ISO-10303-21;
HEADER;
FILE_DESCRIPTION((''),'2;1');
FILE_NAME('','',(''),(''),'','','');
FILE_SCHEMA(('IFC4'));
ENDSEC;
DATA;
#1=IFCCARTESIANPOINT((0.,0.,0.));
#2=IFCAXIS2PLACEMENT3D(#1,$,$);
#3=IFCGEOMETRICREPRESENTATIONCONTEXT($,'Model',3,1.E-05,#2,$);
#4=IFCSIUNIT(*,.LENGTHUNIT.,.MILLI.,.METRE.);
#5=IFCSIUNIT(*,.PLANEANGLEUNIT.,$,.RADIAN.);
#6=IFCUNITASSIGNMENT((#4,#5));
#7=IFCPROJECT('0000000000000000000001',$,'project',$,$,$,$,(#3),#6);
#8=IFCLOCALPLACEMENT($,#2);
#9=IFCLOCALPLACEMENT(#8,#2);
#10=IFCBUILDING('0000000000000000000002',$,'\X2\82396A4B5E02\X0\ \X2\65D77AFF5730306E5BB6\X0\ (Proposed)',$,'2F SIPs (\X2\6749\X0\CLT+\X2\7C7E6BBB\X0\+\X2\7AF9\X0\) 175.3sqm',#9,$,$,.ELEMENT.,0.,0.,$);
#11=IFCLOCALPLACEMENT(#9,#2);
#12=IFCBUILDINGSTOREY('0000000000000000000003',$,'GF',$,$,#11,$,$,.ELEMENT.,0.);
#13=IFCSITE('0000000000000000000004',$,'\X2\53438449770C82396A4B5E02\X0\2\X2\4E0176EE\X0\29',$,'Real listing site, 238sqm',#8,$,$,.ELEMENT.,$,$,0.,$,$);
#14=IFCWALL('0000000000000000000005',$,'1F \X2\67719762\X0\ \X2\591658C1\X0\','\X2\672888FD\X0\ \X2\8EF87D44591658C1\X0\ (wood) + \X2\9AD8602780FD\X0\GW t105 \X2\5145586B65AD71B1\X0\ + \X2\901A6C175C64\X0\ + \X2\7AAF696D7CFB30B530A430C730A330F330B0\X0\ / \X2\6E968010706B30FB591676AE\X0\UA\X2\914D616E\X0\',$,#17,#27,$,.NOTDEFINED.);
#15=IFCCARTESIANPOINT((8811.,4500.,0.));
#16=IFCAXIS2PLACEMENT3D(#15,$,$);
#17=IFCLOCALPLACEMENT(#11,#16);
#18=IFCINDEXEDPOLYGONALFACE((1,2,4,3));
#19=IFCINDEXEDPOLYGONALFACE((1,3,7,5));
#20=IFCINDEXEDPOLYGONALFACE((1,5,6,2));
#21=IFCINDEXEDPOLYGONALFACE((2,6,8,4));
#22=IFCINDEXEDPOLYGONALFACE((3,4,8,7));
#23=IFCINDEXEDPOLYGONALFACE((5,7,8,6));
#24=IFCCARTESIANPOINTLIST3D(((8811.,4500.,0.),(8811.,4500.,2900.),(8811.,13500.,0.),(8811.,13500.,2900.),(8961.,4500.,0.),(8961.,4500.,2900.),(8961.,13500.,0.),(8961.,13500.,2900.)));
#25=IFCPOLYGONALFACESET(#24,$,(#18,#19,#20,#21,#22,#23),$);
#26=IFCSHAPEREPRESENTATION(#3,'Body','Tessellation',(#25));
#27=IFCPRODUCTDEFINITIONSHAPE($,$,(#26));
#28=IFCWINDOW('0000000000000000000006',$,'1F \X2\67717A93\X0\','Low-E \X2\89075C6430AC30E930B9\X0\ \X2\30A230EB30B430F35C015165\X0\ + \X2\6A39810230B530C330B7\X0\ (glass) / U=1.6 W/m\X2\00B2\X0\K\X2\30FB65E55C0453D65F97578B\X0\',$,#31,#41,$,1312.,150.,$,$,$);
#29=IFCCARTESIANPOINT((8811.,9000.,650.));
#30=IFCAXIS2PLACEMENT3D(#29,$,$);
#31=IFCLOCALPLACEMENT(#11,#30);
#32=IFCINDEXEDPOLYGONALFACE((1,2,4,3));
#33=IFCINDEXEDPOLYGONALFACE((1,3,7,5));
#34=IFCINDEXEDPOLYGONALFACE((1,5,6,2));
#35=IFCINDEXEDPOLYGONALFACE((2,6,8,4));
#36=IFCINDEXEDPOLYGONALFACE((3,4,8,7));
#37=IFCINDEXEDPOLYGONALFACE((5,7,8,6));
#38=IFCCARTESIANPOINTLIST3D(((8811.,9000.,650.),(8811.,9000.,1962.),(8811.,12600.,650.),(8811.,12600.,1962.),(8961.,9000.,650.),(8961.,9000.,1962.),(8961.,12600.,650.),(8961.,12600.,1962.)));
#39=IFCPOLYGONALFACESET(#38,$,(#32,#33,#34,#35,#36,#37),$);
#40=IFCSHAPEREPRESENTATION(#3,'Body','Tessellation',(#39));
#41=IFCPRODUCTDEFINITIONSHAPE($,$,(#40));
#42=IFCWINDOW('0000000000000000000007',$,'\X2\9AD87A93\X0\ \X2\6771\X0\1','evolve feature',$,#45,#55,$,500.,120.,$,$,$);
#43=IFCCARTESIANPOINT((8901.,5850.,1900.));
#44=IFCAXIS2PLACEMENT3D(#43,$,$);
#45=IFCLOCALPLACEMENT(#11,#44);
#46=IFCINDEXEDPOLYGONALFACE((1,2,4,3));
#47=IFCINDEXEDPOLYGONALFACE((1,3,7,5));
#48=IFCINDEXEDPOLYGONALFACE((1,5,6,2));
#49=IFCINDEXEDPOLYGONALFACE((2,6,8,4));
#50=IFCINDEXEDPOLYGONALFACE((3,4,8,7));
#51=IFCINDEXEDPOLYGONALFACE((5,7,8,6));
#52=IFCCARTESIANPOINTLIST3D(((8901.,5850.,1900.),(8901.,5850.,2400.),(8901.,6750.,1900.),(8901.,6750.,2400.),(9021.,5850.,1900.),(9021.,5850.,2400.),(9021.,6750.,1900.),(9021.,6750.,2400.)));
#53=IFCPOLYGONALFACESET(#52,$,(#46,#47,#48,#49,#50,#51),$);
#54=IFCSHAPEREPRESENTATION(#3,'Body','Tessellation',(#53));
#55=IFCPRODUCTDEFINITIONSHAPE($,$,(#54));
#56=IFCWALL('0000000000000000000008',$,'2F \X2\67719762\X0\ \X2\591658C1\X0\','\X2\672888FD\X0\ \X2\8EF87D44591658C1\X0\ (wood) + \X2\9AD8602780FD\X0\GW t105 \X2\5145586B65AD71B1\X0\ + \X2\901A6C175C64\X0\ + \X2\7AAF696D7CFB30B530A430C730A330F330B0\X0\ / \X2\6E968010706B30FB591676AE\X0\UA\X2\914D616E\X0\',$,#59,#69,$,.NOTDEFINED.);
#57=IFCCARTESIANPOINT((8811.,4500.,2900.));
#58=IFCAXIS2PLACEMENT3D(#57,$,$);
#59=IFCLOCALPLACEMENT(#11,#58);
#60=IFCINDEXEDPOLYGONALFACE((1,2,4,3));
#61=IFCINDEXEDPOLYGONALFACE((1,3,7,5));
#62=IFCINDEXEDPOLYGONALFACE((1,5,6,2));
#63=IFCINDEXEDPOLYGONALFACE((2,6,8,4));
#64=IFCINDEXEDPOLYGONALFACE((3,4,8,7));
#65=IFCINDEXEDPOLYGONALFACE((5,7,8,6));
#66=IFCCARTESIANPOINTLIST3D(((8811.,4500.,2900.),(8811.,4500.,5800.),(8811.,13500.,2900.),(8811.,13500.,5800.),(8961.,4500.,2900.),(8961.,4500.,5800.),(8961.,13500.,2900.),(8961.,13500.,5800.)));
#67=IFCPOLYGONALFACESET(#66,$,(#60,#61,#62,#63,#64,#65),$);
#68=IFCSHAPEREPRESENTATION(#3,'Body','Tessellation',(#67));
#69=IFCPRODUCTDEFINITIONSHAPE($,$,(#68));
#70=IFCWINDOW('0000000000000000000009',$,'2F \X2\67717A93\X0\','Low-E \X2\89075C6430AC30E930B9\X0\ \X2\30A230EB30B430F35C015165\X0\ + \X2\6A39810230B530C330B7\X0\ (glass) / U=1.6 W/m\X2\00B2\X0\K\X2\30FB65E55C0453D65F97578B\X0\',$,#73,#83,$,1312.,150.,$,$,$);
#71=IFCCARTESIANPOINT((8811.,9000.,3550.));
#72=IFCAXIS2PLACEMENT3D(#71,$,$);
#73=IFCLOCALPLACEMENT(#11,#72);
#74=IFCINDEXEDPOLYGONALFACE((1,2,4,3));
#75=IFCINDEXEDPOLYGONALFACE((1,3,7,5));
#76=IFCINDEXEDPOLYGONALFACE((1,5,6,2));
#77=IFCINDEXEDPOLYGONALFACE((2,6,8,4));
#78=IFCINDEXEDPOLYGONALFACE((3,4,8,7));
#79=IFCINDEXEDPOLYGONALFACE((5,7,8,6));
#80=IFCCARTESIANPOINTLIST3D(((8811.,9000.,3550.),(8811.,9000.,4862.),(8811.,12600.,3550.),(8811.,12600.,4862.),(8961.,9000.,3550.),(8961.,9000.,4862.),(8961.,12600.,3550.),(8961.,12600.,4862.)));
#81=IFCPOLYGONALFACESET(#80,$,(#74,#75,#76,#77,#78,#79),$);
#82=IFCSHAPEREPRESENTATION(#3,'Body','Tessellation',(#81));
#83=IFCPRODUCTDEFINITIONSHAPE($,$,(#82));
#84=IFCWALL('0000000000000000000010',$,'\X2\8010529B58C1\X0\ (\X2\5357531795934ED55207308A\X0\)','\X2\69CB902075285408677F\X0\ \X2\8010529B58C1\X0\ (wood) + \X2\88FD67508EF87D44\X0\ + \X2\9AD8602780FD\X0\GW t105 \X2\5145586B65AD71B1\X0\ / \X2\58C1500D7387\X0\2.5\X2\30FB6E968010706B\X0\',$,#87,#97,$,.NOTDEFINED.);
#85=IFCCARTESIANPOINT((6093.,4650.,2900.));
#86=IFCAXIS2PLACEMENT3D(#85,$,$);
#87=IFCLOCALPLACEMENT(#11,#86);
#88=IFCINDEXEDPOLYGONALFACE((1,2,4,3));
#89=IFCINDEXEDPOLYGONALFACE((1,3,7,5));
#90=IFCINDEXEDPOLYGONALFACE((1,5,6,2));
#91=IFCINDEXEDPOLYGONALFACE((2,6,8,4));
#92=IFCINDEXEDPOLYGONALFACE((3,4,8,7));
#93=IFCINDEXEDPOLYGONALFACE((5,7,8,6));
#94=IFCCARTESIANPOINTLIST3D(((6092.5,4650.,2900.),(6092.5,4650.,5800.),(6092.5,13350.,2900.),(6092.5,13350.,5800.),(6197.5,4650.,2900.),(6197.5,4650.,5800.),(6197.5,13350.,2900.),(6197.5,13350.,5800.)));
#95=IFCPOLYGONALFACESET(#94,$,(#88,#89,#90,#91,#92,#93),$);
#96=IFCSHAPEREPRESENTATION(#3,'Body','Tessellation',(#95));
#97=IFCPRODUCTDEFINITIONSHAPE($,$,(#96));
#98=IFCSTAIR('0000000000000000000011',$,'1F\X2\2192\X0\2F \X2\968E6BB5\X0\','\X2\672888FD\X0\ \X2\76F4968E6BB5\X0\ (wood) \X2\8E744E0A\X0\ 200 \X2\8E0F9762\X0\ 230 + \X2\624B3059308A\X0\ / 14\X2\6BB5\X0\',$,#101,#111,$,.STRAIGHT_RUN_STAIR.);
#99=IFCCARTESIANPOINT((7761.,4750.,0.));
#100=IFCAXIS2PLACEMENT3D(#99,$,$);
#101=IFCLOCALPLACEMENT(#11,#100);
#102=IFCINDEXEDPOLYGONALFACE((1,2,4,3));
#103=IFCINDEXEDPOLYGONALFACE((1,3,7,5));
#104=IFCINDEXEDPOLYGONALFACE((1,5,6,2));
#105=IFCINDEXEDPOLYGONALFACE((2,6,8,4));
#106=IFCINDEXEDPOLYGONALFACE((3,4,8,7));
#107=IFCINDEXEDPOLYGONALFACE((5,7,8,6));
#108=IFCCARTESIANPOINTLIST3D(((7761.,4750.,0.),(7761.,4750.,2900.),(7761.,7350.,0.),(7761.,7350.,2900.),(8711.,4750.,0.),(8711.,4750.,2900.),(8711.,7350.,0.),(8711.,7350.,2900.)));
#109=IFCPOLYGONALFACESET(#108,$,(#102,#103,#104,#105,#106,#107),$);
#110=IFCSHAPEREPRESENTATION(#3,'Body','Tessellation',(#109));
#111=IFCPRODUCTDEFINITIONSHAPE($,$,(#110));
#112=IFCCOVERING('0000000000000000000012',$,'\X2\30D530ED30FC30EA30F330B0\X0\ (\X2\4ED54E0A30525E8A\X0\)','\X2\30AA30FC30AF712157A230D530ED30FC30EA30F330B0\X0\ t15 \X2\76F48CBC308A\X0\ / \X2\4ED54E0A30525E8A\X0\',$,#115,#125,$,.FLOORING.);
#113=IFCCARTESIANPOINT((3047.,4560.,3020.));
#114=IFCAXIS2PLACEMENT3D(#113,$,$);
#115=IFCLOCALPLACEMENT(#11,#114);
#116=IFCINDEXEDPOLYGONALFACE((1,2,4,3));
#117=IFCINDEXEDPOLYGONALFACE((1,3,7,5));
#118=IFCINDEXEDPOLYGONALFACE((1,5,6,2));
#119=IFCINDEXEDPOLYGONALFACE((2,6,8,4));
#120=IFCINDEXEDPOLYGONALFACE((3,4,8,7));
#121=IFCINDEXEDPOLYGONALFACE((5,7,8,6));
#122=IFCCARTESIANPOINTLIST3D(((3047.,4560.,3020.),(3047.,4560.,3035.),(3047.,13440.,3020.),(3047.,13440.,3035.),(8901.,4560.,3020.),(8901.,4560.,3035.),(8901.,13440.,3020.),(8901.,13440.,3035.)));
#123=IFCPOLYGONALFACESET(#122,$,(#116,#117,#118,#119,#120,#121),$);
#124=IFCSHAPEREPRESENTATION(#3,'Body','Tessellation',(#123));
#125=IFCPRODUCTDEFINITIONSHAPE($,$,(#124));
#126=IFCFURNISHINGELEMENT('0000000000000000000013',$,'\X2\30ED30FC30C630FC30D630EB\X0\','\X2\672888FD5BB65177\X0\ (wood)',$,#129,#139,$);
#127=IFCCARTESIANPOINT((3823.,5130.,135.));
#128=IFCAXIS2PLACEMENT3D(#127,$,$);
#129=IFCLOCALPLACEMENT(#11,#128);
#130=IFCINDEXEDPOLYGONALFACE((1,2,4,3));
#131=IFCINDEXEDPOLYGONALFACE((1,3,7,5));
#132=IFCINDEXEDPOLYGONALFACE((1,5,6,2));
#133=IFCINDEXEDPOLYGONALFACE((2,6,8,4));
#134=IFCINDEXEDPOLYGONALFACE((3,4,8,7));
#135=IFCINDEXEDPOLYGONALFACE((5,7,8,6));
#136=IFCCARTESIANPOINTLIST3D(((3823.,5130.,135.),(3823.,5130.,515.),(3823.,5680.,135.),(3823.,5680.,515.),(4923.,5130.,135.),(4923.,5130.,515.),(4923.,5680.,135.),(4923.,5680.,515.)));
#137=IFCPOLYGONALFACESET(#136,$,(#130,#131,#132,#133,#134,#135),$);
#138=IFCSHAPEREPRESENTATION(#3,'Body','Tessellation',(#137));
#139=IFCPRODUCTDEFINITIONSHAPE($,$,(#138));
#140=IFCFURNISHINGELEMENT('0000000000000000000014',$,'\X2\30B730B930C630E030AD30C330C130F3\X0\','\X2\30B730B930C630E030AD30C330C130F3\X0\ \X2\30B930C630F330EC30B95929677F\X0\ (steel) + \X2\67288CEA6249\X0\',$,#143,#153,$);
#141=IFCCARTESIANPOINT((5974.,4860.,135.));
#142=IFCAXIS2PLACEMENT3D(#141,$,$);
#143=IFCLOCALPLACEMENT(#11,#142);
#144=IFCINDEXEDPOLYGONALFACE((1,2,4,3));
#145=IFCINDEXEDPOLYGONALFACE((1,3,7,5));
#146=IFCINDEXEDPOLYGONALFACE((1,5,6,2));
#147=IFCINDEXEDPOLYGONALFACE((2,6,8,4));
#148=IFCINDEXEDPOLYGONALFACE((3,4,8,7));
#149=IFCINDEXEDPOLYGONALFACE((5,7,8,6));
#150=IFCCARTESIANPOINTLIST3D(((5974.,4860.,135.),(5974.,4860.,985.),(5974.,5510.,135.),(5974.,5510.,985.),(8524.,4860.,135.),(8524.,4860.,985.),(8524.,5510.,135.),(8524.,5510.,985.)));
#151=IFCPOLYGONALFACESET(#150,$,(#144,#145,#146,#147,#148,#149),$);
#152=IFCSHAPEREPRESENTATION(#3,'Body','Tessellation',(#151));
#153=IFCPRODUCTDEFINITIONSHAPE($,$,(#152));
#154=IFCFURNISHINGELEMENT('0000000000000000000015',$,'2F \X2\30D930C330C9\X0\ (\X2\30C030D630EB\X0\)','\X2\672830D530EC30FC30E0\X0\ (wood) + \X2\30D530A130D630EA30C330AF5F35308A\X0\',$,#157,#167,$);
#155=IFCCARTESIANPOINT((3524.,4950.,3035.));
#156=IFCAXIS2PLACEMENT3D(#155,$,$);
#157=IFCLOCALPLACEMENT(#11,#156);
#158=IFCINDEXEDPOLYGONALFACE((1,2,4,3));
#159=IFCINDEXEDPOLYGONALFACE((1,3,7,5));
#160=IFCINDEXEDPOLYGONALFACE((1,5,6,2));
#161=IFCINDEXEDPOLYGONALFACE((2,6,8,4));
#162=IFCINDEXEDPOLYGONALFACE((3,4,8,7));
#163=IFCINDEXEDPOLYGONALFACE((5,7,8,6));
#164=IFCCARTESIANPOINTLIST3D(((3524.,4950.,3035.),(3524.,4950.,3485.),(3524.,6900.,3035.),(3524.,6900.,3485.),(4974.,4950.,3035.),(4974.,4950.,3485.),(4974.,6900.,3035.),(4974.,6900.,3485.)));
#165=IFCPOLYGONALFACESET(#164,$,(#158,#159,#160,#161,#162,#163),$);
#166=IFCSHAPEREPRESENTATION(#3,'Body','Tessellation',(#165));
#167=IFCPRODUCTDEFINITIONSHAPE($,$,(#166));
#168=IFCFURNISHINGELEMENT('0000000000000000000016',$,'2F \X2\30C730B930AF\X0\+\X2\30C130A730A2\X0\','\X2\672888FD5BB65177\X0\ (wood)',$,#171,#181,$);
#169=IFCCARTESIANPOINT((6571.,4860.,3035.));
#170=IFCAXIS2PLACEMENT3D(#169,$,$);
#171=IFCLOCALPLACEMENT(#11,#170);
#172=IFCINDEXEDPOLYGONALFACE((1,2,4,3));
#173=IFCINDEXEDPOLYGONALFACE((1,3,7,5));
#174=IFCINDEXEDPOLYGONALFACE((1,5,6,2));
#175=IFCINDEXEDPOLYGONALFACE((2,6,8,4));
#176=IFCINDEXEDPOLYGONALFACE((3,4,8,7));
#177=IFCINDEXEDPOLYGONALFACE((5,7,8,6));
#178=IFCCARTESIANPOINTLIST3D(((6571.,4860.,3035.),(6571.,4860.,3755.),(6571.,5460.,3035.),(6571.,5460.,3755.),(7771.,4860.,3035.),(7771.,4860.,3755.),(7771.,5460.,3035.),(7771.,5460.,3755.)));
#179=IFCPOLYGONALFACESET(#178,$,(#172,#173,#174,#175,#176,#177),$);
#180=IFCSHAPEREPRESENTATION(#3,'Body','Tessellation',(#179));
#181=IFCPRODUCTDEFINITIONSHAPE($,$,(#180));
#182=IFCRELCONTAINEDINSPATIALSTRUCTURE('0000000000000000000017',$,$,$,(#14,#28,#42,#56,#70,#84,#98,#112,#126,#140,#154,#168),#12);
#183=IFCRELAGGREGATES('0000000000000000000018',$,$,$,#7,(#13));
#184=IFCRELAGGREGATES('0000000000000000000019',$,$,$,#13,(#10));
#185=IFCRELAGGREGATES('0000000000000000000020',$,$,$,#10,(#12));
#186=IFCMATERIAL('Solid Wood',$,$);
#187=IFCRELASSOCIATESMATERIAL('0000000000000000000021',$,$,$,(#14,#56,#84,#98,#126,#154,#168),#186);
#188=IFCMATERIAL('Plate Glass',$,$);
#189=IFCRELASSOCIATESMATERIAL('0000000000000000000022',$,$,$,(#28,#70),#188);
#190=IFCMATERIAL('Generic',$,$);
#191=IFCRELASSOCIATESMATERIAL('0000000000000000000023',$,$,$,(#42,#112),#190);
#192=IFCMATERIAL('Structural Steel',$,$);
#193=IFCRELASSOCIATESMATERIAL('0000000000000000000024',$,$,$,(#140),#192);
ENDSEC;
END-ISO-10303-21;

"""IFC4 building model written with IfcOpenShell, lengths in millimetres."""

from ifc_helpers import new_model, si_unit, frame, frame_2d, origin, place, context, project, spatial, rectangle, extrude, material, element, fill, save


model = new_model("IFC4")

# Units and contexts
model_context = context("Model", 3, precision=1e-05, world=origin())
ifc_project = project(units=[si_unit("LENGTHUNIT", "METRE", prefix="MILLI"), si_unit("PLANEANGLEUNIT", "RADIAN")], contexts=[model_context])

# Site, building, storey
site_placement = place(None, origin())
site = spatial("IfcSite", under=ifc_project, at=site_placement, Name="千葉県船橋市2丁目29", ObjectType="Real listing site, 238sqm", CompositionType="ELEMENT", RefElevation=0.0)
building_placement = place(site_placement, origin())
building = spatial("IfcBuilding", under=site, at=building_placement, Name="船橋市 旗竿地の家 (Proposed)", ObjectType="2F SIPs (杉CLT+籾殻+竹) 175.3sqm", CompositionType="ELEMENT", ElevationOfRefHeight=0.0, ElevationOfTerrain=0.0)
storey_placement = place(building_placement, origin())
storey = spatial("IfcBuildingStorey", under=building, at=storey_placement, Name="GF", CompositionType="ELEMENT", Elevation=0.0)

# Shared definitions
ifc_material_1 = material(Name="Solid Wood")

# Wall, openings, windows
wall_1_placement = place(storey_placement, frame((8811.0, 4500.0, 0.0)))
wall_1 = element("IfcWall", 1, at=wall_1_placement, inside=storey, material=ifc_material_1, Name="1F 東面 外壁", Description="木製 軸組外壁 (wood) + 高性能GW t105 充填断熱 + 通気層 + 窯業系サイディング / 準耐火・外皮UA配慮", PredefinedType="NOTDEFINED", context=model_context, shape_type="SweptSolid", body=[
    extrude(rectangle(XDim=150.0, YDim=9000.0, at=frame_2d((75.0, 4500.0))), frame((8811.0, 4500.0, 0.0)), (0.0, 0.0, 1.0), 2900.0),
])
opening_1_placement = place(storey_placement, frame((8811.0, 9000.0, 650.0)))
opening_1 = element("IfcOpeningElement", 2, at=opening_1_placement, cuts=wall_1, PredefinedType="NOTDEFINED", context=model_context, shape_type="SweptSolid", body=[
    extrude(rectangle(XDim=150.0, YDim=3600.0, at=frame_2d((75.0, 1800.0))), frame((8811.0, 9000.0, 650.0)), (0.0, 0.0, 1.0), 1312.0),
])
opening_2_placement = place(storey_placement, frame((8901.0, 5850.0, 1900.0)))
opening_2 = element("IfcOpeningElement", 3, at=opening_2_placement, cuts=wall_1, PredefinedType="NOTDEFINED", context=model_context, shape_type="SweptSolid", body=[
    extrude(rectangle(XDim=120.0, YDim=900.0, at=frame_2d((60.0, 450.0))), frame((8901.0, 5850.0, 1900.0)), (0.0, 0.0, 1.0), 500.0),
])
ifc_material_2 = material(Name="Plate Glass")
window_1_placement = place(storey_placement, frame((8811.0, 9000.0, 650.0)))
window_1 = element("IfcWindow", 4, at=window_1_placement, inside=storey, material=ifc_material_2, Name="1F 東窓", Description="Low-E 複層ガラス アルゴン封入 + 樹脂サッシ (glass) / U=1.6 W/m²K・日射取得型", OverallHeight=1312.0, OverallWidth=150.0, context=model_context, shape_type="SweptSolid", body=[
    extrude(rectangle(XDim=150.0, YDim=3600.0, at=frame_2d((75.0, 1800.0))), frame((8811.0, 9000.0, 650.0)), (0.0, 0.0, 1.0), 1312.0),
])
fill(opening_1, window_1)
ifc_material_3 = material(Name="Generic")
window_2_placement = place(storey_placement, frame((8901.0, 5850.0, 1900.0)))
window_2 = element("IfcWindow", 5, at=window_2_placement, inside=storey, material=ifc_material_3, Name="高窓 東1", Description="evolve feature", OverallHeight=500.0, OverallWidth=120.0, context=model_context, shape_type="SweptSolid", body=[
    extrude(rectangle(XDim=120.0, YDim=900.0, at=frame_2d((60.0, 450.0))), frame((8901.0, 5850.0, 1900.0)), (0.0, 0.0, 1.0), 500.0),
])
fill(opening_2, window_2)

# Wall, opening, window
wall_2_placement = place(storey_placement, frame((8811.0, 4500.0, 2900.0)))
wall_2 = element("IfcWall", 6, at=wall_2_placement, inside=storey, material=ifc_material_1, Name="2F 東面 外壁", Description="木製 軸組外壁 (wood) + 高性能GW t105 充填断熱 + 通気層 + 窯業系サイディング / 準耐火・外皮UA配慮", PredefinedType="NOTDEFINED", context=model_context, shape_type="SweptSolid", body=[
    extrude(rectangle(XDim=150.0, YDim=9000.0, at=frame_2d((75.0, 4500.0))), frame((8811.0, 4500.0, 2900.0)), (0.0, 0.0, 1.0), 2900.0),
])
opening_3_placement = place(storey_placement, frame((8811.0, 9000.0, 3550.0)))
opening_3 = element("IfcOpeningElement", 7, at=opening_3_placement, cuts=wall_2, PredefinedType="NOTDEFINED", context=model_context, shape_type="SweptSolid", body=[
    extrude(rectangle(XDim=150.0, YDim=3600.0, at=frame_2d((75.0, 1800.0))), frame((8811.0, 9000.0, 3550.0)), (0.0, 0.0, 1.0), 1312.0),
])
window_3_placement = place(storey_placement, frame((8811.0, 9000.0, 3550.0)))
window_3 = element("IfcWindow", 8, at=window_3_placement, inside=storey, material=ifc_material_2, Name="2F 東窓", Description="Low-E 複層ガラス アルゴン封入 + 樹脂サッシ (glass) / U=1.6 W/m²K・日射取得型", OverallHeight=1312.0, OverallWidth=150.0, context=model_context, shape_type="SweptSolid", body=[
    extrude(rectangle(XDim=150.0, YDim=3600.0, at=frame_2d((75.0, 1800.0))), frame((8811.0, 9000.0, 3550.0)), (0.0, 0.0, 1.0), 1312.0),
])
fill(opening_3, window_3)

# Wall
wall_3_placement = place(storey_placement, frame((6093.0, 4650.0, 2900.0)))
element("IfcWall", 9, at=wall_3_placement, inside=storey, material=ifc_material_1, Name="耐力壁 (南北間仕切り)", Description="構造用合板 耐力壁 (wood) + 製材軸組 + 高性能GW t105 充填断熱 / 壁倍率2.5・準耐火", PredefinedType="NOTDEFINED", context=model_context, shape_type="SweptSolid", body=[
    extrude(rectangle(XDim=105.0, YDim=8700.0, at=frame_2d((52.0, 4350.0))), frame((6093.0, 4650.0, 2900.0)), (0.0, 0.0, 1.0), 2900.0),
])

# Stair
stair_placement = place(storey_placement, frame((7761.0, 4750.0, 0.0)))
element("IfcStair", 10, at=stair_placement, inside=storey, material=ifc_material_1, Name="1F→2F 階段", Description="木製 直階段 (wood) 蹴上 200 踏面 230 + 手すり / 14段", PredefinedType="STRAIGHT_RUN_STAIR", context=model_context, shape_type="SweptSolid", body=[
    extrude(rectangle(XDim=950.0, YDim=2600.0, at=frame_2d((475.0, 1300.0))), frame((7761.0, 4750.0, 0.0)), (0.0, 0.0, 1.0), 2900.0),
])

# Covering
covering_placement = place(storey_placement, frame((3047.0, 4560.0, 3020.0)))
element("IfcCovering", 11, at=covering_placement, inside=storey, material=ifc_material_3, Name="フローリング (仕上げ床)", Description="オーク無垢フローリング t15 直貼り / 仕上げ床", PredefinedType="FLOORING", context=model_context, shape_type="SweptSolid", body=[
    extrude(rectangle(XDim=5854.0, YDim=8880.0, at=frame_2d((2927.0, 4440.0))), frame((3047.0, 4560.0, 3020.0)), (0.0, 0.0, 1.0), 15.0),
])

# Furnishing elements
furnishing_1_placement = place(storey_placement, frame((3823.0, 5130.0, 135.0)))
element("IfcFurnishingElement", 12, at=furnishing_1_placement, inside=storey, material=ifc_material_1, Name="ローテーブル", Description="木製家具 (wood)", context=model_context, shape_type="SweptSolid", body=[
    extrude(rectangle(XDim=1100.0, YDim=550.0, at=frame_2d((550.0, 275.0))), frame((3823.0, 5130.0, 135.0)), (0.0, 0.0, 1.0), 380.0),
])
ifc_material_4 = material(Name="Structural Steel")
furnishing_2_placement = place(storey_placement, frame((5974.0, 4860.0, 135.0)))
element("IfcFurnishingElement", 13, at=furnishing_2_placement, inside=storey, material=ifc_material_4, Name="システムキッチン", Description="システムキッチン ステンレス天板 (steel) + 木質扉", context=model_context, shape_type="SweptSolid", body=[
    extrude(rectangle(XDim=2550.0, YDim=650.0, at=frame_2d((1275.0, 325.0))), frame((5974.0, 4860.0, 135.0)), (0.0, 0.0, 1.0), 850.0),
])
furnishing_3_placement = place(storey_placement, frame((3524.0, 4950.0, 3035.0)))
element("IfcFurnishingElement", 14, at=furnishing_3_placement, inside=storey, material=ifc_material_1, Name="2F ベッド (ダブル)", Description="木フレーム (wood) + ファブリック張り", context=model_context, shape_type="SweptSolid", body=[
    extrude(rectangle(XDim=1450.0, YDim=1950.0, at=frame_2d((725.0, 975.0))), frame((3524.0, 4950.0, 3035.0)), (0.0, 0.0, 1.0), 450.0),
])
furnishing_4_placement = place(storey_placement, frame((6571.0, 4860.0, 3035.0)))
element("IfcFurnishingElement", 15, at=furnishing_4_placement, inside=storey, material=ifc_material_1, Name="2F デスク+チェア", Description="木製家具 (wood)", context=model_context, shape_type="SweptSolid", body=[
    extrude(rectangle(XDim=1200.0, YDim=600.0, at=frame_2d((600.0, 300.0))), frame((6571.0, 4860.0, 3035.0)), (0.0, 0.0, 1.0), 720.0),
])

save(model, "model.ifc")
